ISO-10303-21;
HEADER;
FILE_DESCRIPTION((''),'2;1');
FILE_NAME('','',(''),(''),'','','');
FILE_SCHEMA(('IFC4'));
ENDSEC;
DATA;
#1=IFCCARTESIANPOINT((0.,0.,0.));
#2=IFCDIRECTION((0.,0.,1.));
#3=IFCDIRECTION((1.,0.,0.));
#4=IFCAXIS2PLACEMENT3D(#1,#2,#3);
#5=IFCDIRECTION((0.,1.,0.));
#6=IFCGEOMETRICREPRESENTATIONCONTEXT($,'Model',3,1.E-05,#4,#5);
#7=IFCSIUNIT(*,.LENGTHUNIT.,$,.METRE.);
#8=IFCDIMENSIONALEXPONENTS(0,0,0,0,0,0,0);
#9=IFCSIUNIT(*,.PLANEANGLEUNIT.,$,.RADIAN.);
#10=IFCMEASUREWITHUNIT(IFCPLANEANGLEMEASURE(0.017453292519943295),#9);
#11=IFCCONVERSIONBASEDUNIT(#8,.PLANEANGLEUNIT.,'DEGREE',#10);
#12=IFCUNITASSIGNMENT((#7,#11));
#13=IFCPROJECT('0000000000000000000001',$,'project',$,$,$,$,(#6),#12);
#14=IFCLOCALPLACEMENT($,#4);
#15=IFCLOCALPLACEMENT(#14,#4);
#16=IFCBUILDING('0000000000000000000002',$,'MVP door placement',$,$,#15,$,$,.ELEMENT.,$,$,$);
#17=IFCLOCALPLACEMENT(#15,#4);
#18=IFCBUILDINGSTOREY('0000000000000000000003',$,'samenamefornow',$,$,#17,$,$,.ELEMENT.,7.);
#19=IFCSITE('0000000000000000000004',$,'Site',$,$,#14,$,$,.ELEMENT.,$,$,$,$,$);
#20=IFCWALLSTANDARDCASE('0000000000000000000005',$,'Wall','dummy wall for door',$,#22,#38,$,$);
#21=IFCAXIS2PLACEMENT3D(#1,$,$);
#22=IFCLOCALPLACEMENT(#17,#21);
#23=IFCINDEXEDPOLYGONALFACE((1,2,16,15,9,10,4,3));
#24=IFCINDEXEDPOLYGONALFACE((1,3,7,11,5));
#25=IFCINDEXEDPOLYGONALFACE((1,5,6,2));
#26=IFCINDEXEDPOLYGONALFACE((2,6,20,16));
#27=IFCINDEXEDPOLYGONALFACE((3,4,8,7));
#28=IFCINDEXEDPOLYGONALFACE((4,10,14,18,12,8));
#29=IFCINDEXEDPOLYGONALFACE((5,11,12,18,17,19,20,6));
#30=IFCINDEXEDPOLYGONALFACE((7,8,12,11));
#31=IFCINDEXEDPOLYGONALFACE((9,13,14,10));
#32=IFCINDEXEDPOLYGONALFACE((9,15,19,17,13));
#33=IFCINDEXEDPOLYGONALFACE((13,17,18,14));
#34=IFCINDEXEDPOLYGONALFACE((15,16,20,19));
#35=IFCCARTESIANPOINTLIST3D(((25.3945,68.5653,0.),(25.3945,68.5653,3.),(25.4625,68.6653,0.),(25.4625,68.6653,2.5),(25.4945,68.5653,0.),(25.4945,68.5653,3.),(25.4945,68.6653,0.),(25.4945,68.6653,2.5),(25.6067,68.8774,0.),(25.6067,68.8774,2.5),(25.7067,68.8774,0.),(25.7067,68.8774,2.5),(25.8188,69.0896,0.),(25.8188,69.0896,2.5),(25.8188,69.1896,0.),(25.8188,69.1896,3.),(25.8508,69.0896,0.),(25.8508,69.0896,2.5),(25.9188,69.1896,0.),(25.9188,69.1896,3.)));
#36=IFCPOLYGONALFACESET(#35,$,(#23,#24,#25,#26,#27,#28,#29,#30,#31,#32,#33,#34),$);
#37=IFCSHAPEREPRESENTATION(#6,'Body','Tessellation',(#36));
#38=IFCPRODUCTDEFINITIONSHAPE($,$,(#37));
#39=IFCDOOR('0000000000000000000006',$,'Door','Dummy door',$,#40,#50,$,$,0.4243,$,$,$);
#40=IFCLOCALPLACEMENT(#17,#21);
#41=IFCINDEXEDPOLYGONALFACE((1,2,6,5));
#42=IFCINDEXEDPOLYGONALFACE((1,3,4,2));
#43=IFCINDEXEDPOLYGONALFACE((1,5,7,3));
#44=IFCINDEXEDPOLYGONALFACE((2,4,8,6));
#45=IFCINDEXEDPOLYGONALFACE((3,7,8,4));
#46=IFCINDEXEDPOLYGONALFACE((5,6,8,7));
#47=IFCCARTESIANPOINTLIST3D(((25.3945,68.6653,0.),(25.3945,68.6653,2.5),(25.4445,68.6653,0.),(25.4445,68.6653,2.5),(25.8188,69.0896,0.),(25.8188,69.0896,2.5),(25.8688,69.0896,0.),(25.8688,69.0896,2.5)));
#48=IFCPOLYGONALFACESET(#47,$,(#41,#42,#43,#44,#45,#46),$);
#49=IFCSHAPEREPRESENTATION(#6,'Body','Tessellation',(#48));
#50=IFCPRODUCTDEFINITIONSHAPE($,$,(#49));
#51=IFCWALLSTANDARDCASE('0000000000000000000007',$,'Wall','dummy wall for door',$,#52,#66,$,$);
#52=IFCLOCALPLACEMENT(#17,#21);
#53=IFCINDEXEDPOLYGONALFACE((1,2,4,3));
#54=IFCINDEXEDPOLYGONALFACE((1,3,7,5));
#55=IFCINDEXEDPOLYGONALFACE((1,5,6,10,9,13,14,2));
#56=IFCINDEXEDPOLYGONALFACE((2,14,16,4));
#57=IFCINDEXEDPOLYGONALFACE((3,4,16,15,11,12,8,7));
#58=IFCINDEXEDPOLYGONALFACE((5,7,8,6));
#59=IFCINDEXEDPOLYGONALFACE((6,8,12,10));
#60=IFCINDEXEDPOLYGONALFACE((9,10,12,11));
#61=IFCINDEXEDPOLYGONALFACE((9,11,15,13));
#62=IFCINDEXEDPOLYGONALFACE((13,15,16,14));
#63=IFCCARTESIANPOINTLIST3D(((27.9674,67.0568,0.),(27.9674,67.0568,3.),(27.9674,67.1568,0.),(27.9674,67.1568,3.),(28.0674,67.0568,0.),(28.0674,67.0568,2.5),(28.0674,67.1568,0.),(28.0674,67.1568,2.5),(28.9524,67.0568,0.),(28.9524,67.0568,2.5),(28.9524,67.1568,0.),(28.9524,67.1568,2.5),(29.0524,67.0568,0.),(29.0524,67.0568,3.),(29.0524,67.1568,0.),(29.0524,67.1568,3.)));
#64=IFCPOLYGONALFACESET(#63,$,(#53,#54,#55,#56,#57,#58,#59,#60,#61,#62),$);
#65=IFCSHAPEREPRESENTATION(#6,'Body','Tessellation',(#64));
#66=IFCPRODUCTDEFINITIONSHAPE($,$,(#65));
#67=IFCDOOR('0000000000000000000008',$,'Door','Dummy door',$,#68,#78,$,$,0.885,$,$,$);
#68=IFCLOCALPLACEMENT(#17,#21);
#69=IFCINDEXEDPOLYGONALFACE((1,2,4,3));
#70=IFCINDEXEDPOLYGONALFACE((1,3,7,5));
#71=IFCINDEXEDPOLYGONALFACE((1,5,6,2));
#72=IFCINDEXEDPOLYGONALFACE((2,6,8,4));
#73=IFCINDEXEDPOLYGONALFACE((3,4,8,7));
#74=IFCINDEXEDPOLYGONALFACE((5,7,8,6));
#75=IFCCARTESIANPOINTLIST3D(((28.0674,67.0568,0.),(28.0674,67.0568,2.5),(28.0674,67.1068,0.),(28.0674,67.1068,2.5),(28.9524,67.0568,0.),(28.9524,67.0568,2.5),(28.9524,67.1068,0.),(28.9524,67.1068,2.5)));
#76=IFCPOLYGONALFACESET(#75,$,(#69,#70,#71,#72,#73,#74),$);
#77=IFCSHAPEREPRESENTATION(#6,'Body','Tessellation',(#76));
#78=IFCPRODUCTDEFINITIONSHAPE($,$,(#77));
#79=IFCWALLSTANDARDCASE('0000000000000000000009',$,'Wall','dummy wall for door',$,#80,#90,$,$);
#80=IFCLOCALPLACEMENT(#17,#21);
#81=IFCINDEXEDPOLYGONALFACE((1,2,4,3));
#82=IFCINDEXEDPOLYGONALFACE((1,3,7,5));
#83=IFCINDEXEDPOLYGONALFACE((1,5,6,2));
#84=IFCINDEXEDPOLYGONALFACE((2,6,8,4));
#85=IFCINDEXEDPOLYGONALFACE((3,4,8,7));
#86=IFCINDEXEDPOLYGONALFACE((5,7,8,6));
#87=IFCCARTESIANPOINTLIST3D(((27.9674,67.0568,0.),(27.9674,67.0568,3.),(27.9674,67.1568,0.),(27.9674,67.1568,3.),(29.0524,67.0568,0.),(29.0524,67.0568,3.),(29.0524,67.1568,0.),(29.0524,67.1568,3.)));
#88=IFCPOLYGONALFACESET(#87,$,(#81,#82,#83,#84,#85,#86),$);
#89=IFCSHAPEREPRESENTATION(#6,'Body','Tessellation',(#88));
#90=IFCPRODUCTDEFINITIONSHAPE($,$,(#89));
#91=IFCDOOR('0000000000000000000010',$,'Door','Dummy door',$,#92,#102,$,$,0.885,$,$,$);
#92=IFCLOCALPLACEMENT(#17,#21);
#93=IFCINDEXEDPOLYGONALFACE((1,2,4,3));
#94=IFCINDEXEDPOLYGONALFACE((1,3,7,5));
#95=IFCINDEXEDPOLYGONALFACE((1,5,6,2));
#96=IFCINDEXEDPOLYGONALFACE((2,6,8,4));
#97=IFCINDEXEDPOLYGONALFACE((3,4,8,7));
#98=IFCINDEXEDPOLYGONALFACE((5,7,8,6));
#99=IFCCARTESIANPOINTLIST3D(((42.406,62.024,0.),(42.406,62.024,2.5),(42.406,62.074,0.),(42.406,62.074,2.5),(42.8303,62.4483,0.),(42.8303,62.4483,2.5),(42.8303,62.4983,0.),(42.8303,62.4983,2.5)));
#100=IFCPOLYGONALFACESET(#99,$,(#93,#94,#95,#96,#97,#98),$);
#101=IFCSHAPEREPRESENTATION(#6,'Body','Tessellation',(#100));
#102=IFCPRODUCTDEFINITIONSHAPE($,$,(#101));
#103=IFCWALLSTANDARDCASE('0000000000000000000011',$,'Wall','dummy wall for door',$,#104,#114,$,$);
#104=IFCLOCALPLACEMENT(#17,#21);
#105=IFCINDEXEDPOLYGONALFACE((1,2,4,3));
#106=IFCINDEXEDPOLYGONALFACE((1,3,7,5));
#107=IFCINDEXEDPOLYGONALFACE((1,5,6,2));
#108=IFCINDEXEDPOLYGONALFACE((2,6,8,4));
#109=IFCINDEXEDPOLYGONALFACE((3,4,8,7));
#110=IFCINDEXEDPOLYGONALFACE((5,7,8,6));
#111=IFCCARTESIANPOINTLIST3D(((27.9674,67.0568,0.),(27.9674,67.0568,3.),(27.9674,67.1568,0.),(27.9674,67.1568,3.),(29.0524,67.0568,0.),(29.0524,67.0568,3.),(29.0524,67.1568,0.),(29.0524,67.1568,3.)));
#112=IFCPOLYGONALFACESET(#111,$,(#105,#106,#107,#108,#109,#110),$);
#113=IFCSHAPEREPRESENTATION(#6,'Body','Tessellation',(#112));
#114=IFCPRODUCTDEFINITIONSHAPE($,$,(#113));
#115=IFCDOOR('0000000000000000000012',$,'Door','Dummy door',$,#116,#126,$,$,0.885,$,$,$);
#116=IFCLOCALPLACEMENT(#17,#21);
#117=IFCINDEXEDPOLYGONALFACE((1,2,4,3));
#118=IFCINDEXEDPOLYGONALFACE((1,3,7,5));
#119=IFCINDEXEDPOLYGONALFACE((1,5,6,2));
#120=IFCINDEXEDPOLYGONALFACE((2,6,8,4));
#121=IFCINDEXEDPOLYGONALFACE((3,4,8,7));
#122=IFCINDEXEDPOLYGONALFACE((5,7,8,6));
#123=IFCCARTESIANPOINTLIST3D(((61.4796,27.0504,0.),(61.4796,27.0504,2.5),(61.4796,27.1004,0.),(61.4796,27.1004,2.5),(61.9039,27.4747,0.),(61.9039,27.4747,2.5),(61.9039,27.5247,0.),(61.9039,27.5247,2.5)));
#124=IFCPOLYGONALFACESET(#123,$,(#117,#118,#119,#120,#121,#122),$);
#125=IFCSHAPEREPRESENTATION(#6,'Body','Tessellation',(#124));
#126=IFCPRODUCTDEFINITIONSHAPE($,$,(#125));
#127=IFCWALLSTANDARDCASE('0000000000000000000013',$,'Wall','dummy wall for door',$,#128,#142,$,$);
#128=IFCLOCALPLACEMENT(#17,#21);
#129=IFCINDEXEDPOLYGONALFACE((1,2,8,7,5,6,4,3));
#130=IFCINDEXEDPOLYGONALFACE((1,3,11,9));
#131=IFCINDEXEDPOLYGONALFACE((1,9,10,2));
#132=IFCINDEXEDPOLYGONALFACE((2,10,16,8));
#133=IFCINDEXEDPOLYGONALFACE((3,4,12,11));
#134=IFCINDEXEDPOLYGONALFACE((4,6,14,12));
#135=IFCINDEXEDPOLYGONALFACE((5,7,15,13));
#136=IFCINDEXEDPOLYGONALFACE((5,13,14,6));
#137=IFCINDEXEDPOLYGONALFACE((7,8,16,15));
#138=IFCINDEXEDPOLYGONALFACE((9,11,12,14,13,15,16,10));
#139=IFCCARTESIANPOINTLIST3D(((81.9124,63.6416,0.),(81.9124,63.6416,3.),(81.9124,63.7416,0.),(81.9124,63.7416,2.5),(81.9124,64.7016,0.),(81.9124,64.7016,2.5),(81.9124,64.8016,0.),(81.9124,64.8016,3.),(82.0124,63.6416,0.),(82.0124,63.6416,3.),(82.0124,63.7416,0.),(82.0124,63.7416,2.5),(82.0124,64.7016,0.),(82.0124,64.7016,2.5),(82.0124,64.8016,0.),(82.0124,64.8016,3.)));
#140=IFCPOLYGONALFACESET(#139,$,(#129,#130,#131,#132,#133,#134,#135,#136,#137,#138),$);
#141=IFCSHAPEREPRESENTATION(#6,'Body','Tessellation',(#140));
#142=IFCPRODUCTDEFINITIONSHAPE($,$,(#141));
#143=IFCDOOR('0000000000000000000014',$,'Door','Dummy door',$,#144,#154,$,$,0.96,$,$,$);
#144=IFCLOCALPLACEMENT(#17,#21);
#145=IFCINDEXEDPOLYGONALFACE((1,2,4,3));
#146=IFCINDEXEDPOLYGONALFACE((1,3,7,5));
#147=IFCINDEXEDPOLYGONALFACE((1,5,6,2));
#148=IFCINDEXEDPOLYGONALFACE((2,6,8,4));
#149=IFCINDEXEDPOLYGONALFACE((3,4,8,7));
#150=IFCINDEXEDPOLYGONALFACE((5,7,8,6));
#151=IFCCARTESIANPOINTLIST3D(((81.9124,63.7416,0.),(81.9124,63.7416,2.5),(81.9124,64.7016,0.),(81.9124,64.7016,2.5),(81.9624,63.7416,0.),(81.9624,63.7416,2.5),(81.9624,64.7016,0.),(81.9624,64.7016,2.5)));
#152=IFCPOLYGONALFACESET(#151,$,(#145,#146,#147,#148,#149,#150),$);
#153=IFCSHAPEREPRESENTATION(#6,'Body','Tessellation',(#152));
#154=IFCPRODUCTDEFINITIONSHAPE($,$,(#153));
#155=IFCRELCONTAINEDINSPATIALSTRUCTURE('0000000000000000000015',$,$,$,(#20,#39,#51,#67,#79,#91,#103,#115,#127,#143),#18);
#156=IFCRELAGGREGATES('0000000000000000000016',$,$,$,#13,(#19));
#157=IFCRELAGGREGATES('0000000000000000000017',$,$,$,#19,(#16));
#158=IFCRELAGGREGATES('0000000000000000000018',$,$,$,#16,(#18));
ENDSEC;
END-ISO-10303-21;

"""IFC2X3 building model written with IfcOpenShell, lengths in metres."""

from ifc_helpers import new_model, entity, si_unit, converted_unit, direction, origin_with_axes, place, context, project, spatial, polyline, outline, extrude, element, fill, save


model = new_model("IFC2X3")

# Units and contexts
model_context = context("Model", 3, precision=1e-05, world=origin_with_axes(), true_north=direction((0.0, 1.0, 0.0)))
ifc_project = project(units=[si_unit("LENGTHUNIT", "METRE"), converted_unit("PLANEANGLEUNIT", "DEGREE", entity("IfcPlaneAngleMeasure", 0.017453292519943295), si_unit("PLANEANGLEUNIT", "RADIAN"), dimensions=[0, 0, 0, 0, 0, 0, 0])], contexts=[model_context])

# Site, building, storey
site_placement = place(None, origin_with_axes())
site = spatial("IfcSite", under=ifc_project, at=site_placement, Name="Site", CompositionType="ELEMENT")
building_placement = place(site_placement, origin_with_axes())
building = spatial("IfcBuilding", under=site, at=building_placement, Name="MVP door placement", CompositionType="ELEMENT")
storey_placement = place(building_placement, origin_with_axes())
storey = spatial("IfcBuildingStorey", under=building, at=storey_placement, Name="samenamefornow", CompositionType="ELEMENT", Elevation=7.0)

# Walls, openings, doors
wall_1_placement = place(storey_placement, origin_with_axes())
wall_1 = element("IfcWallStandardCase", 1, at=wall_1_placement, inside=storey, Name="Wall", Description="dummy wall for door", context=model_context, shape_type="SweptSolid", body=[
    extrude(outline(polyline([(25.8188, 69.1896, 0.0), (25.3945, 68.5653, 0.0), (25.4945, 68.5653, 0.0), (25.9188, 69.1896, 0.0), (25.8188, 69.1896, 0.0)])), origin_with_axes(), (0.0, 0.0, 1.0), 3.0),
])
opening_1_placement = place(wall_1_placement, origin_with_axes())
opening_1 = element("IfcOpeningElement", 2, at=opening_1_placement, cuts=wall_1, context=model_context, shape_type="SweptSolid", body=[
    extrude(outline(polyline([(25.8188, 69.0896, 0.0), (25.3945, 68.6653, 0.0), (25.4945, 68.6653, 0.0), (25.9188, 69.0896, 0.0), (25.8188, 69.0896, 0.0)])), origin_with_axes(), (0.0, 0.0, 1.0), 2.5),
])
door_1_placement = place(opening_1_placement, origin_with_axes())
door_1 = element("IfcDoor", 3, at=door_1_placement, inside=storey, Name="Door", Description="Dummy door", OverallWidth=0.4243, context=model_context, shape_type="SweptSolid", body=[
    extrude(outline(polyline([(25.8188, 69.0896, 0.0), (25.3945, 68.6653, 0.0), (25.4445, 68.6653, 0.0), (25.8688, 69.0896, 0.0), (25.8188, 69.0896, 0.0)])), origin_with_axes(), (0.0, 0.0, 1.0), 2.5),
])
fill(opening_1, door_1)
wall_2_placement = place(storey_placement, origin_with_axes())
wall_2 = element("IfcWallStandardCase", 4, at=wall_2_placement, inside=storey, Name="Wall", Description="dummy wall for door", context=model_context, shape_type="SweptSolid", body=[
    extrude(outline(polyline([(27.9674, 67.0568, 0.0), (29.0524, 67.0568, 0.0), (29.0524, 67.1568, 0.0), (27.9674, 67.1568, 0.0), (27.9674, 67.0568, 0.0)])), origin_with_axes(), (0.0, 0.0, 1.0), 3.0),
])
opening_2_placement = place(wall_2_placement, origin_with_axes())
opening_2 = element("IfcOpeningElement", 5, at=opening_2_placement, cuts=wall_2, context=model_context, shape_type="SweptSolid", body=[
    extrude(outline(polyline([(28.0674, 67.0568, 0.0), (28.9524, 67.0568, 0.0), (28.9524, 67.1568, 0.0), (28.0674, 67.1568, 0.0), (28.0674, 67.0568, 0.0)])), origin_with_axes(), (0.0, 0.0, 1.0), 2.5),
])
door_2_placement = place(opening_2_placement, origin_with_axes())
door_2 = element("IfcDoor", 6, at=door_2_placement, inside=storey, Name="Door", Description="Dummy door", OverallWidth=0.885, context=model_context, shape_type="SweptSolid", body=[
    extrude(outline(polyline([(28.0674, 67.0568, 0.0), (28.9524, 67.0568, 0.0), (28.9524, 67.1068, 0.0), (28.0674, 67.1068, 0.0), (28.0674, 67.0568, 0.0)])), origin_with_axes(), (0.0, 0.0, 1.0), 2.5),
])
fill(opening_2, door_2)
wall_3_placement = place(storey_placement, origin_with_axes())
wall_3 = element("IfcWallStandardCase", 7, at=wall_3_placement, inside=storey, Name="Wall", Description="dummy wall for door", context=model_context, shape_type="SweptSolid", body=[
    extrude(outline(polyline([(27.9674, 67.0568, 0.0), (29.0524, 67.0568, 0.0), (29.0524, 67.1568, 0.0), (27.9674, 67.1568, 0.0), (27.9674, 67.0568, 0.0)])), origin_with_axes(), (0.0, 0.0, 1.0), 3.0),
])
opening_3_placement = place(wall_3_placement, origin_with_axes())
opening_3 = element("IfcOpeningElement", 8, at=opening_3_placement, cuts=wall_3, context=model_context, shape_type="SweptSolid", body=[
    extrude(outline(polyline([(42.406, 62.024, 0.0), (42.8303, 62.4483, 0.0), (42.8303, 62.5483, 0.0), (42.406, 62.124, 0.0), (42.406, 62.024, 0.0)])), origin_with_axes(), (0.0, 0.0, 1.0), 2.5),
])
door_3_placement = place(opening_3_placement, origin_with_axes())
door_3 = element("IfcDoor", 9, at=door_3_placement, inside=storey, Name="Door", Description="Dummy door", OverallWidth=0.885, context=model_context, shape_type="SweptSolid", body=[
    extrude(outline(polyline([(42.406, 62.024, 0.0), (42.8303, 62.4483, 0.0), (42.8303, 62.4983, 0.0), (42.406, 62.074, 0.0), (42.406, 62.024, 0.0)])), origin_with_axes(), (0.0, 0.0, 1.0), 2.5),
])
fill(opening_3, door_3)
wall_4_placement = place(storey_placement, origin_with_axes())
wall_4 = element("IfcWallStandardCase", 10, at=wall_4_placement, inside=storey, Name="Wall", Description="dummy wall for door", context=model_context, shape_type="SweptSolid", body=[
    extrude(outline(polyline([(27.9674, 67.0568, 0.0), (29.0524, 67.0568, 0.0), (29.0524, 67.1568, 0.0), (27.9674, 67.1568, 0.0), (27.9674, 67.0568, 0.0)])), origin_with_axes(), (0.0, 0.0, 1.0), 3.0),
])
opening_4_placement = place(wall_4_placement, origin_with_axes())
opening_4 = element("IfcOpeningElement", 11, at=opening_4_placement, cuts=wall_4, context=model_context, shape_type="SweptSolid", body=[
    extrude(outline(polyline([(61.4796, 27.0504, 0.0), (61.9039, 27.4747, 0.0), (61.9039, 27.5747, 0.0), (61.4796, 27.1504, 0.0), (61.4796, 27.0504, 0.0)])), origin_with_axes(), (0.0, 0.0, 1.0), 2.5),
])
door_4_placement = place(opening_4_placement, origin_with_axes())
door_4 = element("IfcDoor", 12, at=door_4_placement, inside=storey, Name="Door", Description="Dummy door", OverallWidth=0.885, context=model_context, shape_type="SweptSolid", body=[
    extrude(outline(polyline([(61.4796, 27.0504, 0.0), (61.9039, 27.4747, 0.0), (61.9039, 27.5247, 0.0), (61.4796, 27.1004, 0.0), (61.4796, 27.0504, 0.0)])), origin_with_axes(), (0.0, 0.0, 1.0), 2.5),
])
fill(opening_4, door_4)
wall_5_placement = place(storey_placement, origin_with_axes())
wall_5 = element("IfcWallStandardCase", 13, at=wall_5_placement, inside=storey, Name="Wall", Description="dummy wall for door", context=model_context, shape_type="SweptSolid", body=[
    extrude(outline(polyline([(81.9124, 63.6416, 0.0), (81.9124, 64.8016, 0.0), (82.0124, 64.8016, 0.0), (82.0124, 63.6416, 0.0), (81.9124, 63.6416, 0.0)])), origin_with_axes(), (0.0, 0.0, 1.0), 3.0),
])
opening_5_placement = place(wall_5_placement, origin_with_axes())
opening_5 = element("IfcOpeningElement", 14, at=opening_5_placement, cuts=wall_5, context=model_context, shape_type="SweptSolid", body=[
    extrude(outline(polyline([(81.9124, 63.7416, 0.0), (81.9124, 64.7016, 0.0), (82.0124, 64.7016, 0.0), (82.0124, 63.7416, 0.0), (81.9124, 63.7416, 0.0)])), origin_with_axes(), (0.0, 0.0, 1.0), 2.5),
])
door_5_placement = place(opening_5_placement, origin_with_axes())
door_5 = element("IfcDoor", 15, at=door_5_placement, inside=storey, Name="Door", Description="Dummy door", OverallWidth=0.96, context=model_context, shape_type="SweptSolid", body=[
    extrude(outline(polyline([(81.9124, 63.7416, 0.0), (81.9124, 64.7016, 0.0), (81.9624, 64.7016, 0.0), (81.9624, 63.7416, 0.0), (81.9124, 63.7416, 0.0)])), origin_with_axes(), (0.0, 0.0, 1.0), 2.5),
])
fill(opening_5, door_5)

save(model, "model.ifc")
